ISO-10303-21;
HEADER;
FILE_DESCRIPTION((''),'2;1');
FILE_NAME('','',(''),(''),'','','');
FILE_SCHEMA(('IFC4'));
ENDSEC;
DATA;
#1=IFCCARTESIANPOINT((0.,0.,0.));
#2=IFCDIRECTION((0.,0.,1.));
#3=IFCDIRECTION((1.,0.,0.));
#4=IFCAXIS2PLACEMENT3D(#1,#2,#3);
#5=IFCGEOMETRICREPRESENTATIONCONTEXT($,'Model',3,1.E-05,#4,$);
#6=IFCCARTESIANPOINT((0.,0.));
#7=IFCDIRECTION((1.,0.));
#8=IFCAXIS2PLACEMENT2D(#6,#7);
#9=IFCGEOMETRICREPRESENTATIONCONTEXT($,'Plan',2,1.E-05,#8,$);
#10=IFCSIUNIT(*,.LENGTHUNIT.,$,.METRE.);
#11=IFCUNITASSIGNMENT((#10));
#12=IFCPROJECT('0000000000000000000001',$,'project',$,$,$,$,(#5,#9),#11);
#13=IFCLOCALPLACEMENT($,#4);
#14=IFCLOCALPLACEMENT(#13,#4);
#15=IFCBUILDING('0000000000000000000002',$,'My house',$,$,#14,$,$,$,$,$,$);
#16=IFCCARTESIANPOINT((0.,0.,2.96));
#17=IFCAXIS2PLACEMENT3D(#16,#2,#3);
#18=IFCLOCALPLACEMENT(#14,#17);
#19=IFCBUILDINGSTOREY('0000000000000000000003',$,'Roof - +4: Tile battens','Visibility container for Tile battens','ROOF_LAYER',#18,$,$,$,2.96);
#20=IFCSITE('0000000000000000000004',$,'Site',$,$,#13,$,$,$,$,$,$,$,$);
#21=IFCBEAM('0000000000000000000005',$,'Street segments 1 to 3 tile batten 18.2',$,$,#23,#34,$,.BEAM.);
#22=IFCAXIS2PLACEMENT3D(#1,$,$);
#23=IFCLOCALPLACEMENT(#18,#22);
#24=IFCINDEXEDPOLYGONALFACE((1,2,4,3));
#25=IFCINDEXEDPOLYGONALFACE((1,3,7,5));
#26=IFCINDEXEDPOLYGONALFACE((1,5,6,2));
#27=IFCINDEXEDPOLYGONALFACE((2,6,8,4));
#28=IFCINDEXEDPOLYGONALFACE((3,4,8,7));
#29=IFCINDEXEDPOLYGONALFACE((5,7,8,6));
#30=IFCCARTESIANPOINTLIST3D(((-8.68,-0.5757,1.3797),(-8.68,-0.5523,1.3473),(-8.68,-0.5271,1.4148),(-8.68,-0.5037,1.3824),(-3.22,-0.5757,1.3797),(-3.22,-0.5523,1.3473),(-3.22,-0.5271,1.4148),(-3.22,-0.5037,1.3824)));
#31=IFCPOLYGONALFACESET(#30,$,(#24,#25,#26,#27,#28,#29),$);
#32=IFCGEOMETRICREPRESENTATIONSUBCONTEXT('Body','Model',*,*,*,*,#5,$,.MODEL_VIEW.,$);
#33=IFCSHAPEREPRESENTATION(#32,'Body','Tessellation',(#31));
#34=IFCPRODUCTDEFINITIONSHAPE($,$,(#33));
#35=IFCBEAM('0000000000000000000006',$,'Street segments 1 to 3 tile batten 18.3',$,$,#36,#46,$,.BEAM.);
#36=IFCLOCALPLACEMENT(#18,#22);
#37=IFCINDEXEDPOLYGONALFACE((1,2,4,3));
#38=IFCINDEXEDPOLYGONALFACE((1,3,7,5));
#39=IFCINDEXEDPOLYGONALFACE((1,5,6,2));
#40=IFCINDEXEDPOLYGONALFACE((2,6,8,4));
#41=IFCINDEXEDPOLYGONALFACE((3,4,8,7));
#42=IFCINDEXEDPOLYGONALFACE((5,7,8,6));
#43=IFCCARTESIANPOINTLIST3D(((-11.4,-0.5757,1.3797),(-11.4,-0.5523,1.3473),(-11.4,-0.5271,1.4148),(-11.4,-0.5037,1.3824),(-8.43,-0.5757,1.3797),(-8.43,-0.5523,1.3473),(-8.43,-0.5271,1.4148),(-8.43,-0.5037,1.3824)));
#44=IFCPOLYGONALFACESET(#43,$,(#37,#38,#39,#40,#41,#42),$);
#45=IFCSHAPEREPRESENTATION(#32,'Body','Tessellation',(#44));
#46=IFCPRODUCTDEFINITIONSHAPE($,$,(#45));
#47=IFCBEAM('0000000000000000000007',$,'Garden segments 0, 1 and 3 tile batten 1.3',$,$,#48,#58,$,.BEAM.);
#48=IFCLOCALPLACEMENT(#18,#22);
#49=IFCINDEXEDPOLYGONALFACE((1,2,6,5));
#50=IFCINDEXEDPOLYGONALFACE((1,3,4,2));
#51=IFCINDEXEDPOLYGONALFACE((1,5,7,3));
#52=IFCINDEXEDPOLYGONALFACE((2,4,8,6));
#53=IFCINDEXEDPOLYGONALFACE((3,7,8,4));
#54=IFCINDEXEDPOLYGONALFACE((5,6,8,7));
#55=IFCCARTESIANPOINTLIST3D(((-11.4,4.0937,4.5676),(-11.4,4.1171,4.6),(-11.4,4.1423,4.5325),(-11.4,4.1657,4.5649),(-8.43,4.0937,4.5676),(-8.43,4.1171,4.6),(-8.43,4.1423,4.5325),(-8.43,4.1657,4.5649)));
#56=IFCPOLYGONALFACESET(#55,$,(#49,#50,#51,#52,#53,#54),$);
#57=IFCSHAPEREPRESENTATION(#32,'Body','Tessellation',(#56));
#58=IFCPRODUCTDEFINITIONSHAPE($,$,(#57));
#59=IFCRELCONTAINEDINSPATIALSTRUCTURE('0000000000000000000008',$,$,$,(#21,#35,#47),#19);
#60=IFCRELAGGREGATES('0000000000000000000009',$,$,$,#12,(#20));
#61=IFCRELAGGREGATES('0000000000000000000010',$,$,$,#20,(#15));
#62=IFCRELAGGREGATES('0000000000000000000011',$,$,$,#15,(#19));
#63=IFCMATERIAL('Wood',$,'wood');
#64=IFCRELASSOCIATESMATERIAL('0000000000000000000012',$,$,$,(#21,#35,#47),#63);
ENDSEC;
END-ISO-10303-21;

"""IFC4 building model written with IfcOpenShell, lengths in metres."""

from ifc_helpers import new_model, si_unit, frame, origin_with_axes, origin_2d_with_axis, place, context, subcontext, project, spatial, rectangle, extrude, clip, halfspace, source, transform, mapped, material, element, save


model = new_model("IFC4")

# Units and contexts
model_context = context("Model", 3, precision=1e-05, world=origin_with_axes())
plan_context = context("Plan", 2, precision=1e-05, world=origin_2d_with_axis())
body_context = subcontext(model_context, "Body", "Model", "MODEL_VIEW")
ifc_project = project(units=[si_unit("LENGTHUNIT", "METRE")], contexts=[model_context, plan_context])

# Site, building, storey
site_placement = place(None, origin_with_axes())
site = spatial("IfcSite", under=ifc_project, at=site_placement, Name="Site")
building_placement = place(site_placement, origin_with_axes())
building = spatial("IfcBuilding", under=site, at=building_placement, Name="My house")
storey_placement = place(building_placement, frame((0.0, 0.0, 2.96), z_axis=(0.0, 0.0, 1.0), x_axis=(1.0, 0.0, 0.0)))
storey = spatial("IfcBuildingStorey", under=building, at=storey_placement, Name="Roof - +4: Tile battens", Description="Visibility container for Tile battens", ObjectType="ROOF_LAYER", Elevation=2.96)

# Beams
ifc_material = material(Name="Wood", Category="wood")
shared_shape_1 = source(origin_with_axes(), body_context, "Body", "Clipping", [
    clip(clip(extrude(rectangle(XDim=0.06, YDim=0.04), frame((0.0, 0.0, 0.0), z_axis=(1.0, 0.0, 0.0), x_axis=(0.0, 1.0, 0.0)), (0.0, 0.0, 1.0), 5.46), halfspace(frame((-3.22, 1.1384, -6.1772), z_axis=(0.0, 0.810664, -0.585512), x_axis=(1.0, 0.0, 0.0)), False)), halfspace(frame((-3.22, -2.7122, -3.396), z_axis=(0.0, -0.810664, 0.585512), x_axis=(-1.0, 0.0, 0.0)), False)),
])
beam_1_placement = place(storey_placement, frame((-3.22, -0.5397, 1.3811), z_axis=(0.0, -0.585512, 0.810664), x_axis=(1.0, 0.0, 0.0)))
element("IfcBeam", 1, at=beam_1_placement, inside=storey, material=ifc_material, Name="Street segments 1 to 3 tile batten 18.2", PredefinedType="BEAM", context=body_context, shape_type="MappedRepresentation", body=[
    mapped(shared_shape_1, transform((0.0, 0.0, 0.0), x_axis=(-1.0, 0.0, 0.0), y_axis=(0.0, 1.0, 0.0), z_axis=(0.0, 0.0, 1.0), scale=1.0)),
])
shared_shape_2 = source(origin_with_axes(), body_context, "Body", "Clipping", [
    clip(clip(extrude(rectangle(XDim=0.06, YDim=0.04), frame((0.0, 0.0, 0.0), z_axis=(1.0, 0.0, 0.0), x_axis=(0.0, 1.0, 0.0)), (0.0, 0.0, 1.0), 2.97), halfspace(frame((-8.43, 1.1384, -6.1772), z_axis=(0.0, 0.810664, -0.585512), x_axis=(1.0, 0.0, 0.0)), False)), halfspace(frame((-8.43, -2.7122, -3.396), z_axis=(0.0, -0.810664, 0.585512), x_axis=(-1.0, 0.0, 0.0)), False)),
])
beam_2_placement = place(storey_placement, frame((-8.43, -0.5397, 1.3811), z_axis=(0.0, -0.585512, 0.810664), x_axis=(1.0, 0.0, 0.0)))
element("IfcBeam", 2, at=beam_2_placement, inside=storey, material=ifc_material, Name="Street segments 1 to 3 tile batten 18.3", PredefinedType="BEAM", context=body_context, shape_type="MappedRepresentation", body=[
    mapped(shared_shape_2, transform((0.0, 0.0, 0.0), x_axis=(-1.0, 0.0, 0.0), y_axis=(0.0, 1.0, 0.0), z_axis=(0.0, 0.0, 1.0), scale=1.0)),
])
shared_shape_3 = source(origin_with_axes(), body_context, "Body", "Clipping", [
    clip(clip(extrude(rectangle(XDim=0.06, YDim=0.04), frame((0.0, 0.0, 0.0), z_axis=(1.0, 0.0, 0.0), x_axis=(0.0, 1.0, 0.0)), (0.0, 0.0, 1.0), 2.97), halfspace(frame((-8.43, 4.3016, -6.1772), z_axis=(0.0, -0.810664, -0.585512), x_axis=(-1.0, 0.0, 0.0)), False)), halfspace(frame((-8.43, 8.1522, -3.396), z_axis=(0.0, 0.810664, 0.585512), x_axis=(1.0, 0.0, 0.0)), False)),
])
beam_3_placement = place(storey_placement, frame((-8.43, 4.1297, 4.5663), z_axis=(0.0, 0.585512, 0.810664), x_axis=(1.0, 0.0, 0.0)))
element("IfcBeam", 3, at=beam_3_placement, inside=storey, material=ifc_material, Name="Garden segments 0, 1 and 3 tile batten 1.3", PredefinedType="BEAM", context=body_context, shape_type="MappedRepresentation", body=[
    mapped(shared_shape_3, transform((0.0, 0.0, 0.0), x_axis=(-1.0, 0.0, 0.0), y_axis=(0.0, 1.0, 0.0), z_axis=(0.0, 0.0, 1.0), scale=1.0)),
])

save(model, "model.ifc")
